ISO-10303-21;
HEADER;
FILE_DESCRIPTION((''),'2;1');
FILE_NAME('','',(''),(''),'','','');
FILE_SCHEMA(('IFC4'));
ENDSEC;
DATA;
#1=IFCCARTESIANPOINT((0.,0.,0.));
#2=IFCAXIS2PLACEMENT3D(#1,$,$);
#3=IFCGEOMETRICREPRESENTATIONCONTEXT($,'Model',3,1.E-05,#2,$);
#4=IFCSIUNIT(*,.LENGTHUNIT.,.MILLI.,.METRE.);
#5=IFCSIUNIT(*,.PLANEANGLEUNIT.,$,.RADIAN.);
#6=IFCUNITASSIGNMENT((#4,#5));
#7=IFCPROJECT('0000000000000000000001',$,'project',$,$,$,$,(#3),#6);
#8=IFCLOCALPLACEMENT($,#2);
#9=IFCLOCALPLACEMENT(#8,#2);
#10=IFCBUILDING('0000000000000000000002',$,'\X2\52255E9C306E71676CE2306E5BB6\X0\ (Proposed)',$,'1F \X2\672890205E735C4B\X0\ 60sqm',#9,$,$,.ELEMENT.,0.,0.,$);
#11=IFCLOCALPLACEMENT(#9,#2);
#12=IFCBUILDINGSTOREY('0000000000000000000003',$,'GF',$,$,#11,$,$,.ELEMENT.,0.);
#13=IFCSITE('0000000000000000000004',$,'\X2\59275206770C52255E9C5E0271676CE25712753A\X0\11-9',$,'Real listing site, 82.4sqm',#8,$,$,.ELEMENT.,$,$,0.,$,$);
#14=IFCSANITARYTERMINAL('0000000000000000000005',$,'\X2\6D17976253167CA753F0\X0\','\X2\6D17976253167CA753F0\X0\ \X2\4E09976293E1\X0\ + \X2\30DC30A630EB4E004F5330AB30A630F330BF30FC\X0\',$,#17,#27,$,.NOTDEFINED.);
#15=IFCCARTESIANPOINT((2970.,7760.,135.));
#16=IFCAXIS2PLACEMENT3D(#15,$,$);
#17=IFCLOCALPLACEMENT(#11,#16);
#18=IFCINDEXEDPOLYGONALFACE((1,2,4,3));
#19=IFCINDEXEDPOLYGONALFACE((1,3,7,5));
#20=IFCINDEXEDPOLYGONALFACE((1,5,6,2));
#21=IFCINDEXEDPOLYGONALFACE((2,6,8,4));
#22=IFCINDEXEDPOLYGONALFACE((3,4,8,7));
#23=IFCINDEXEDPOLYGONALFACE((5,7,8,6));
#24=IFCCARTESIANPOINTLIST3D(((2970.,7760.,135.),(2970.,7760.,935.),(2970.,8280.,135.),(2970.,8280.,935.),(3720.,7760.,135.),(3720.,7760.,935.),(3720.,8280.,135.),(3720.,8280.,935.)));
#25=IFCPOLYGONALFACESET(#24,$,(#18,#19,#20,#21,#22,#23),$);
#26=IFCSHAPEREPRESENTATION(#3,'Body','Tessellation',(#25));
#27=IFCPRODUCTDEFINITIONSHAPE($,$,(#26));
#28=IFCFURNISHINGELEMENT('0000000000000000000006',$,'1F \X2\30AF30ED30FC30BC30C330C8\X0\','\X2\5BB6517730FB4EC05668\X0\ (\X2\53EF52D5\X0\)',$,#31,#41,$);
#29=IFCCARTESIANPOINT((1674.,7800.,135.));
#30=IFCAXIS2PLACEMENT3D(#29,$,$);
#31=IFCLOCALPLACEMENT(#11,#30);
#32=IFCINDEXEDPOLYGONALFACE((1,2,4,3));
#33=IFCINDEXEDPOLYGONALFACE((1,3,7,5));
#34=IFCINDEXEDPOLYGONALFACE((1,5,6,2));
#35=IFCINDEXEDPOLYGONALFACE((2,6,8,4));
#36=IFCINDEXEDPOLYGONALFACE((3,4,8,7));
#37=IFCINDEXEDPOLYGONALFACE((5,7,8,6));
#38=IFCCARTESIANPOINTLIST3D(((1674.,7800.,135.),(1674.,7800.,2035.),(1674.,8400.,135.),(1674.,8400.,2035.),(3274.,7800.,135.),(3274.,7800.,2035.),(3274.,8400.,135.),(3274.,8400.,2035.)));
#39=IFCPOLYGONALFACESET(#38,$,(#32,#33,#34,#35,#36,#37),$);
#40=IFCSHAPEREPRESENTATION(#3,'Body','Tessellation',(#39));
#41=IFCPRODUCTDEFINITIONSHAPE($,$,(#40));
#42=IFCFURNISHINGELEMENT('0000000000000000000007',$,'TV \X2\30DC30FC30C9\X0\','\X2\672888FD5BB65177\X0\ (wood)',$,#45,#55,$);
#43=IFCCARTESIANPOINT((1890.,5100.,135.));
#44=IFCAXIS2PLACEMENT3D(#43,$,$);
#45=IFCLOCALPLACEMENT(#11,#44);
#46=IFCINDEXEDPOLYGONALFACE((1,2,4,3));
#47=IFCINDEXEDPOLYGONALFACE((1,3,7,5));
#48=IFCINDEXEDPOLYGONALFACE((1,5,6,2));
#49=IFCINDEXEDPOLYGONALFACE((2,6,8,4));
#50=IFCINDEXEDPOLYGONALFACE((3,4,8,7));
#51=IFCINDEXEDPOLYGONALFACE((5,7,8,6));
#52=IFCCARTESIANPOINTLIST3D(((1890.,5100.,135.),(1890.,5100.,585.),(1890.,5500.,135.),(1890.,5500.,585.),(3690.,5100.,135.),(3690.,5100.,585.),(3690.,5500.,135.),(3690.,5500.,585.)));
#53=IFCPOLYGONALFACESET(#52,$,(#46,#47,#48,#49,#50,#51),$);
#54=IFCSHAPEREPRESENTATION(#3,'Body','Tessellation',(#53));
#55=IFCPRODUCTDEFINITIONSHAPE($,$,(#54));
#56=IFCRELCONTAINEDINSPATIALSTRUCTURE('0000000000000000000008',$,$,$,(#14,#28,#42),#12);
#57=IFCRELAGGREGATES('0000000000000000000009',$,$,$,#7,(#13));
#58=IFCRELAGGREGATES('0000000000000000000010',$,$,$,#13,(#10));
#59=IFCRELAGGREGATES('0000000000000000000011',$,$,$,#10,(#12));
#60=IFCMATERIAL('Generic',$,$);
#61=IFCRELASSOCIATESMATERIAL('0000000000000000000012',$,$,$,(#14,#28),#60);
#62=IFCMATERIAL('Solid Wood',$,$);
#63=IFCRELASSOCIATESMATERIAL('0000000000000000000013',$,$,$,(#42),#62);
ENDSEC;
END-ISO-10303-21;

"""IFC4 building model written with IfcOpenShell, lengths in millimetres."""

from ifc_helpers import new_model, si_unit, frame, frame_2d, origin, place, context, project, spatial, rectangle, extrude, material, element, save


model = new_model("IFC4")

# Units and contexts
model_context = context("Model", 3, precision=1e-05, world=origin())
ifc_project = project(units=[si_unit("LENGTHUNIT", "METRE", prefix="MILLI"), si_unit("PLANEANGLEUNIT", "RADIAN")], contexts=[model_context])

# Site, building, storey
site_placement = place(None, origin())
site = spatial("IfcSite", under=ifc_project, at=site_placement, Name="大分県別府市照波園町11-9", ObjectType="Real listing site, 82.4sqm", CompositionType="ELEMENT", RefElevation=0.0)
building_placement = place(site_placement, origin())
building = spatial("IfcBuilding", under=site, at=building_placement, Name="別府の照波の家 (Proposed)", ObjectType="1F 木造平屋 60sqm", CompositionType="ELEMENT", ElevationOfRefHeight=0.0, ElevationOfTerrain=0.0)
storey_placement = place(building_placement, origin())
storey = spatial("IfcBuildingStorey", under=building, at=storey_placement, Name="GF", CompositionType="ELEMENT", Elevation=0.0)

# Shared definitions
ifc_material_1 = material(Name="Solid Wood")

# Shared definitions
ifc_material_2 = material(Name="Generic")

# Sanitary terminal
sanitary_terminal_1_placement = place(storey_placement, frame((2970.0, 7760.0, 135.0)))
element("IfcSanitaryTerminal", 1, at=sanitary_terminal_1_placement, inside=storey, material=ifc_material_2, Name="洗面化粧台", Description="洗面化粧台 三面鏡 + ボウル一体カウンター", PredefinedType="NOTDEFINED", context=model_context, shape_type="SweptSolid", body=[
    extrude(rectangle(XDim=750.0, YDim=520.0, at=frame_2d((375.0, 260.0))), frame((2970.0, 7760.0, 135.0)), (0.0, 0.0, 1.0), 800.0),
])

# Furnishing elements
furnishing_1_placement = place(storey_placement, frame((1674.0, 7800.0, 135.0)))
element("IfcFurnishingElement", 2, at=furnishing_1_placement, inside=storey, material=ifc_material_2, Name="1F クローゼット", Description="家具・什器 (可動)", context=model_context, shape_type="SweptSolid", body=[
    extrude(rectangle(XDim=1600.0, YDim=600.0, at=frame_2d((800.0, 300.0))), frame((1674.0, 7800.0, 135.0)), (0.0, 0.0, 1.0), 1900.0),
])
furnishing_2_placement = place(storey_placement, frame((1890.0, 5100.0, 135.0)))
element("IfcFurnishingElement", 3, at=furnishing_2_placement, inside=storey, material=ifc_material_1, Name="TV ボード", Description="木製家具 (wood)", context=model_context, shape_type="SweptSolid", body=[
    extrude(rectangle(XDim=1800.0, YDim=400.0, at=frame_2d((900.0, 200.0))), frame((1890.0, 5100.0, 135.0)), (0.0, 0.0, 1.0), 450.0),
])

save(model, "model.ifc")
